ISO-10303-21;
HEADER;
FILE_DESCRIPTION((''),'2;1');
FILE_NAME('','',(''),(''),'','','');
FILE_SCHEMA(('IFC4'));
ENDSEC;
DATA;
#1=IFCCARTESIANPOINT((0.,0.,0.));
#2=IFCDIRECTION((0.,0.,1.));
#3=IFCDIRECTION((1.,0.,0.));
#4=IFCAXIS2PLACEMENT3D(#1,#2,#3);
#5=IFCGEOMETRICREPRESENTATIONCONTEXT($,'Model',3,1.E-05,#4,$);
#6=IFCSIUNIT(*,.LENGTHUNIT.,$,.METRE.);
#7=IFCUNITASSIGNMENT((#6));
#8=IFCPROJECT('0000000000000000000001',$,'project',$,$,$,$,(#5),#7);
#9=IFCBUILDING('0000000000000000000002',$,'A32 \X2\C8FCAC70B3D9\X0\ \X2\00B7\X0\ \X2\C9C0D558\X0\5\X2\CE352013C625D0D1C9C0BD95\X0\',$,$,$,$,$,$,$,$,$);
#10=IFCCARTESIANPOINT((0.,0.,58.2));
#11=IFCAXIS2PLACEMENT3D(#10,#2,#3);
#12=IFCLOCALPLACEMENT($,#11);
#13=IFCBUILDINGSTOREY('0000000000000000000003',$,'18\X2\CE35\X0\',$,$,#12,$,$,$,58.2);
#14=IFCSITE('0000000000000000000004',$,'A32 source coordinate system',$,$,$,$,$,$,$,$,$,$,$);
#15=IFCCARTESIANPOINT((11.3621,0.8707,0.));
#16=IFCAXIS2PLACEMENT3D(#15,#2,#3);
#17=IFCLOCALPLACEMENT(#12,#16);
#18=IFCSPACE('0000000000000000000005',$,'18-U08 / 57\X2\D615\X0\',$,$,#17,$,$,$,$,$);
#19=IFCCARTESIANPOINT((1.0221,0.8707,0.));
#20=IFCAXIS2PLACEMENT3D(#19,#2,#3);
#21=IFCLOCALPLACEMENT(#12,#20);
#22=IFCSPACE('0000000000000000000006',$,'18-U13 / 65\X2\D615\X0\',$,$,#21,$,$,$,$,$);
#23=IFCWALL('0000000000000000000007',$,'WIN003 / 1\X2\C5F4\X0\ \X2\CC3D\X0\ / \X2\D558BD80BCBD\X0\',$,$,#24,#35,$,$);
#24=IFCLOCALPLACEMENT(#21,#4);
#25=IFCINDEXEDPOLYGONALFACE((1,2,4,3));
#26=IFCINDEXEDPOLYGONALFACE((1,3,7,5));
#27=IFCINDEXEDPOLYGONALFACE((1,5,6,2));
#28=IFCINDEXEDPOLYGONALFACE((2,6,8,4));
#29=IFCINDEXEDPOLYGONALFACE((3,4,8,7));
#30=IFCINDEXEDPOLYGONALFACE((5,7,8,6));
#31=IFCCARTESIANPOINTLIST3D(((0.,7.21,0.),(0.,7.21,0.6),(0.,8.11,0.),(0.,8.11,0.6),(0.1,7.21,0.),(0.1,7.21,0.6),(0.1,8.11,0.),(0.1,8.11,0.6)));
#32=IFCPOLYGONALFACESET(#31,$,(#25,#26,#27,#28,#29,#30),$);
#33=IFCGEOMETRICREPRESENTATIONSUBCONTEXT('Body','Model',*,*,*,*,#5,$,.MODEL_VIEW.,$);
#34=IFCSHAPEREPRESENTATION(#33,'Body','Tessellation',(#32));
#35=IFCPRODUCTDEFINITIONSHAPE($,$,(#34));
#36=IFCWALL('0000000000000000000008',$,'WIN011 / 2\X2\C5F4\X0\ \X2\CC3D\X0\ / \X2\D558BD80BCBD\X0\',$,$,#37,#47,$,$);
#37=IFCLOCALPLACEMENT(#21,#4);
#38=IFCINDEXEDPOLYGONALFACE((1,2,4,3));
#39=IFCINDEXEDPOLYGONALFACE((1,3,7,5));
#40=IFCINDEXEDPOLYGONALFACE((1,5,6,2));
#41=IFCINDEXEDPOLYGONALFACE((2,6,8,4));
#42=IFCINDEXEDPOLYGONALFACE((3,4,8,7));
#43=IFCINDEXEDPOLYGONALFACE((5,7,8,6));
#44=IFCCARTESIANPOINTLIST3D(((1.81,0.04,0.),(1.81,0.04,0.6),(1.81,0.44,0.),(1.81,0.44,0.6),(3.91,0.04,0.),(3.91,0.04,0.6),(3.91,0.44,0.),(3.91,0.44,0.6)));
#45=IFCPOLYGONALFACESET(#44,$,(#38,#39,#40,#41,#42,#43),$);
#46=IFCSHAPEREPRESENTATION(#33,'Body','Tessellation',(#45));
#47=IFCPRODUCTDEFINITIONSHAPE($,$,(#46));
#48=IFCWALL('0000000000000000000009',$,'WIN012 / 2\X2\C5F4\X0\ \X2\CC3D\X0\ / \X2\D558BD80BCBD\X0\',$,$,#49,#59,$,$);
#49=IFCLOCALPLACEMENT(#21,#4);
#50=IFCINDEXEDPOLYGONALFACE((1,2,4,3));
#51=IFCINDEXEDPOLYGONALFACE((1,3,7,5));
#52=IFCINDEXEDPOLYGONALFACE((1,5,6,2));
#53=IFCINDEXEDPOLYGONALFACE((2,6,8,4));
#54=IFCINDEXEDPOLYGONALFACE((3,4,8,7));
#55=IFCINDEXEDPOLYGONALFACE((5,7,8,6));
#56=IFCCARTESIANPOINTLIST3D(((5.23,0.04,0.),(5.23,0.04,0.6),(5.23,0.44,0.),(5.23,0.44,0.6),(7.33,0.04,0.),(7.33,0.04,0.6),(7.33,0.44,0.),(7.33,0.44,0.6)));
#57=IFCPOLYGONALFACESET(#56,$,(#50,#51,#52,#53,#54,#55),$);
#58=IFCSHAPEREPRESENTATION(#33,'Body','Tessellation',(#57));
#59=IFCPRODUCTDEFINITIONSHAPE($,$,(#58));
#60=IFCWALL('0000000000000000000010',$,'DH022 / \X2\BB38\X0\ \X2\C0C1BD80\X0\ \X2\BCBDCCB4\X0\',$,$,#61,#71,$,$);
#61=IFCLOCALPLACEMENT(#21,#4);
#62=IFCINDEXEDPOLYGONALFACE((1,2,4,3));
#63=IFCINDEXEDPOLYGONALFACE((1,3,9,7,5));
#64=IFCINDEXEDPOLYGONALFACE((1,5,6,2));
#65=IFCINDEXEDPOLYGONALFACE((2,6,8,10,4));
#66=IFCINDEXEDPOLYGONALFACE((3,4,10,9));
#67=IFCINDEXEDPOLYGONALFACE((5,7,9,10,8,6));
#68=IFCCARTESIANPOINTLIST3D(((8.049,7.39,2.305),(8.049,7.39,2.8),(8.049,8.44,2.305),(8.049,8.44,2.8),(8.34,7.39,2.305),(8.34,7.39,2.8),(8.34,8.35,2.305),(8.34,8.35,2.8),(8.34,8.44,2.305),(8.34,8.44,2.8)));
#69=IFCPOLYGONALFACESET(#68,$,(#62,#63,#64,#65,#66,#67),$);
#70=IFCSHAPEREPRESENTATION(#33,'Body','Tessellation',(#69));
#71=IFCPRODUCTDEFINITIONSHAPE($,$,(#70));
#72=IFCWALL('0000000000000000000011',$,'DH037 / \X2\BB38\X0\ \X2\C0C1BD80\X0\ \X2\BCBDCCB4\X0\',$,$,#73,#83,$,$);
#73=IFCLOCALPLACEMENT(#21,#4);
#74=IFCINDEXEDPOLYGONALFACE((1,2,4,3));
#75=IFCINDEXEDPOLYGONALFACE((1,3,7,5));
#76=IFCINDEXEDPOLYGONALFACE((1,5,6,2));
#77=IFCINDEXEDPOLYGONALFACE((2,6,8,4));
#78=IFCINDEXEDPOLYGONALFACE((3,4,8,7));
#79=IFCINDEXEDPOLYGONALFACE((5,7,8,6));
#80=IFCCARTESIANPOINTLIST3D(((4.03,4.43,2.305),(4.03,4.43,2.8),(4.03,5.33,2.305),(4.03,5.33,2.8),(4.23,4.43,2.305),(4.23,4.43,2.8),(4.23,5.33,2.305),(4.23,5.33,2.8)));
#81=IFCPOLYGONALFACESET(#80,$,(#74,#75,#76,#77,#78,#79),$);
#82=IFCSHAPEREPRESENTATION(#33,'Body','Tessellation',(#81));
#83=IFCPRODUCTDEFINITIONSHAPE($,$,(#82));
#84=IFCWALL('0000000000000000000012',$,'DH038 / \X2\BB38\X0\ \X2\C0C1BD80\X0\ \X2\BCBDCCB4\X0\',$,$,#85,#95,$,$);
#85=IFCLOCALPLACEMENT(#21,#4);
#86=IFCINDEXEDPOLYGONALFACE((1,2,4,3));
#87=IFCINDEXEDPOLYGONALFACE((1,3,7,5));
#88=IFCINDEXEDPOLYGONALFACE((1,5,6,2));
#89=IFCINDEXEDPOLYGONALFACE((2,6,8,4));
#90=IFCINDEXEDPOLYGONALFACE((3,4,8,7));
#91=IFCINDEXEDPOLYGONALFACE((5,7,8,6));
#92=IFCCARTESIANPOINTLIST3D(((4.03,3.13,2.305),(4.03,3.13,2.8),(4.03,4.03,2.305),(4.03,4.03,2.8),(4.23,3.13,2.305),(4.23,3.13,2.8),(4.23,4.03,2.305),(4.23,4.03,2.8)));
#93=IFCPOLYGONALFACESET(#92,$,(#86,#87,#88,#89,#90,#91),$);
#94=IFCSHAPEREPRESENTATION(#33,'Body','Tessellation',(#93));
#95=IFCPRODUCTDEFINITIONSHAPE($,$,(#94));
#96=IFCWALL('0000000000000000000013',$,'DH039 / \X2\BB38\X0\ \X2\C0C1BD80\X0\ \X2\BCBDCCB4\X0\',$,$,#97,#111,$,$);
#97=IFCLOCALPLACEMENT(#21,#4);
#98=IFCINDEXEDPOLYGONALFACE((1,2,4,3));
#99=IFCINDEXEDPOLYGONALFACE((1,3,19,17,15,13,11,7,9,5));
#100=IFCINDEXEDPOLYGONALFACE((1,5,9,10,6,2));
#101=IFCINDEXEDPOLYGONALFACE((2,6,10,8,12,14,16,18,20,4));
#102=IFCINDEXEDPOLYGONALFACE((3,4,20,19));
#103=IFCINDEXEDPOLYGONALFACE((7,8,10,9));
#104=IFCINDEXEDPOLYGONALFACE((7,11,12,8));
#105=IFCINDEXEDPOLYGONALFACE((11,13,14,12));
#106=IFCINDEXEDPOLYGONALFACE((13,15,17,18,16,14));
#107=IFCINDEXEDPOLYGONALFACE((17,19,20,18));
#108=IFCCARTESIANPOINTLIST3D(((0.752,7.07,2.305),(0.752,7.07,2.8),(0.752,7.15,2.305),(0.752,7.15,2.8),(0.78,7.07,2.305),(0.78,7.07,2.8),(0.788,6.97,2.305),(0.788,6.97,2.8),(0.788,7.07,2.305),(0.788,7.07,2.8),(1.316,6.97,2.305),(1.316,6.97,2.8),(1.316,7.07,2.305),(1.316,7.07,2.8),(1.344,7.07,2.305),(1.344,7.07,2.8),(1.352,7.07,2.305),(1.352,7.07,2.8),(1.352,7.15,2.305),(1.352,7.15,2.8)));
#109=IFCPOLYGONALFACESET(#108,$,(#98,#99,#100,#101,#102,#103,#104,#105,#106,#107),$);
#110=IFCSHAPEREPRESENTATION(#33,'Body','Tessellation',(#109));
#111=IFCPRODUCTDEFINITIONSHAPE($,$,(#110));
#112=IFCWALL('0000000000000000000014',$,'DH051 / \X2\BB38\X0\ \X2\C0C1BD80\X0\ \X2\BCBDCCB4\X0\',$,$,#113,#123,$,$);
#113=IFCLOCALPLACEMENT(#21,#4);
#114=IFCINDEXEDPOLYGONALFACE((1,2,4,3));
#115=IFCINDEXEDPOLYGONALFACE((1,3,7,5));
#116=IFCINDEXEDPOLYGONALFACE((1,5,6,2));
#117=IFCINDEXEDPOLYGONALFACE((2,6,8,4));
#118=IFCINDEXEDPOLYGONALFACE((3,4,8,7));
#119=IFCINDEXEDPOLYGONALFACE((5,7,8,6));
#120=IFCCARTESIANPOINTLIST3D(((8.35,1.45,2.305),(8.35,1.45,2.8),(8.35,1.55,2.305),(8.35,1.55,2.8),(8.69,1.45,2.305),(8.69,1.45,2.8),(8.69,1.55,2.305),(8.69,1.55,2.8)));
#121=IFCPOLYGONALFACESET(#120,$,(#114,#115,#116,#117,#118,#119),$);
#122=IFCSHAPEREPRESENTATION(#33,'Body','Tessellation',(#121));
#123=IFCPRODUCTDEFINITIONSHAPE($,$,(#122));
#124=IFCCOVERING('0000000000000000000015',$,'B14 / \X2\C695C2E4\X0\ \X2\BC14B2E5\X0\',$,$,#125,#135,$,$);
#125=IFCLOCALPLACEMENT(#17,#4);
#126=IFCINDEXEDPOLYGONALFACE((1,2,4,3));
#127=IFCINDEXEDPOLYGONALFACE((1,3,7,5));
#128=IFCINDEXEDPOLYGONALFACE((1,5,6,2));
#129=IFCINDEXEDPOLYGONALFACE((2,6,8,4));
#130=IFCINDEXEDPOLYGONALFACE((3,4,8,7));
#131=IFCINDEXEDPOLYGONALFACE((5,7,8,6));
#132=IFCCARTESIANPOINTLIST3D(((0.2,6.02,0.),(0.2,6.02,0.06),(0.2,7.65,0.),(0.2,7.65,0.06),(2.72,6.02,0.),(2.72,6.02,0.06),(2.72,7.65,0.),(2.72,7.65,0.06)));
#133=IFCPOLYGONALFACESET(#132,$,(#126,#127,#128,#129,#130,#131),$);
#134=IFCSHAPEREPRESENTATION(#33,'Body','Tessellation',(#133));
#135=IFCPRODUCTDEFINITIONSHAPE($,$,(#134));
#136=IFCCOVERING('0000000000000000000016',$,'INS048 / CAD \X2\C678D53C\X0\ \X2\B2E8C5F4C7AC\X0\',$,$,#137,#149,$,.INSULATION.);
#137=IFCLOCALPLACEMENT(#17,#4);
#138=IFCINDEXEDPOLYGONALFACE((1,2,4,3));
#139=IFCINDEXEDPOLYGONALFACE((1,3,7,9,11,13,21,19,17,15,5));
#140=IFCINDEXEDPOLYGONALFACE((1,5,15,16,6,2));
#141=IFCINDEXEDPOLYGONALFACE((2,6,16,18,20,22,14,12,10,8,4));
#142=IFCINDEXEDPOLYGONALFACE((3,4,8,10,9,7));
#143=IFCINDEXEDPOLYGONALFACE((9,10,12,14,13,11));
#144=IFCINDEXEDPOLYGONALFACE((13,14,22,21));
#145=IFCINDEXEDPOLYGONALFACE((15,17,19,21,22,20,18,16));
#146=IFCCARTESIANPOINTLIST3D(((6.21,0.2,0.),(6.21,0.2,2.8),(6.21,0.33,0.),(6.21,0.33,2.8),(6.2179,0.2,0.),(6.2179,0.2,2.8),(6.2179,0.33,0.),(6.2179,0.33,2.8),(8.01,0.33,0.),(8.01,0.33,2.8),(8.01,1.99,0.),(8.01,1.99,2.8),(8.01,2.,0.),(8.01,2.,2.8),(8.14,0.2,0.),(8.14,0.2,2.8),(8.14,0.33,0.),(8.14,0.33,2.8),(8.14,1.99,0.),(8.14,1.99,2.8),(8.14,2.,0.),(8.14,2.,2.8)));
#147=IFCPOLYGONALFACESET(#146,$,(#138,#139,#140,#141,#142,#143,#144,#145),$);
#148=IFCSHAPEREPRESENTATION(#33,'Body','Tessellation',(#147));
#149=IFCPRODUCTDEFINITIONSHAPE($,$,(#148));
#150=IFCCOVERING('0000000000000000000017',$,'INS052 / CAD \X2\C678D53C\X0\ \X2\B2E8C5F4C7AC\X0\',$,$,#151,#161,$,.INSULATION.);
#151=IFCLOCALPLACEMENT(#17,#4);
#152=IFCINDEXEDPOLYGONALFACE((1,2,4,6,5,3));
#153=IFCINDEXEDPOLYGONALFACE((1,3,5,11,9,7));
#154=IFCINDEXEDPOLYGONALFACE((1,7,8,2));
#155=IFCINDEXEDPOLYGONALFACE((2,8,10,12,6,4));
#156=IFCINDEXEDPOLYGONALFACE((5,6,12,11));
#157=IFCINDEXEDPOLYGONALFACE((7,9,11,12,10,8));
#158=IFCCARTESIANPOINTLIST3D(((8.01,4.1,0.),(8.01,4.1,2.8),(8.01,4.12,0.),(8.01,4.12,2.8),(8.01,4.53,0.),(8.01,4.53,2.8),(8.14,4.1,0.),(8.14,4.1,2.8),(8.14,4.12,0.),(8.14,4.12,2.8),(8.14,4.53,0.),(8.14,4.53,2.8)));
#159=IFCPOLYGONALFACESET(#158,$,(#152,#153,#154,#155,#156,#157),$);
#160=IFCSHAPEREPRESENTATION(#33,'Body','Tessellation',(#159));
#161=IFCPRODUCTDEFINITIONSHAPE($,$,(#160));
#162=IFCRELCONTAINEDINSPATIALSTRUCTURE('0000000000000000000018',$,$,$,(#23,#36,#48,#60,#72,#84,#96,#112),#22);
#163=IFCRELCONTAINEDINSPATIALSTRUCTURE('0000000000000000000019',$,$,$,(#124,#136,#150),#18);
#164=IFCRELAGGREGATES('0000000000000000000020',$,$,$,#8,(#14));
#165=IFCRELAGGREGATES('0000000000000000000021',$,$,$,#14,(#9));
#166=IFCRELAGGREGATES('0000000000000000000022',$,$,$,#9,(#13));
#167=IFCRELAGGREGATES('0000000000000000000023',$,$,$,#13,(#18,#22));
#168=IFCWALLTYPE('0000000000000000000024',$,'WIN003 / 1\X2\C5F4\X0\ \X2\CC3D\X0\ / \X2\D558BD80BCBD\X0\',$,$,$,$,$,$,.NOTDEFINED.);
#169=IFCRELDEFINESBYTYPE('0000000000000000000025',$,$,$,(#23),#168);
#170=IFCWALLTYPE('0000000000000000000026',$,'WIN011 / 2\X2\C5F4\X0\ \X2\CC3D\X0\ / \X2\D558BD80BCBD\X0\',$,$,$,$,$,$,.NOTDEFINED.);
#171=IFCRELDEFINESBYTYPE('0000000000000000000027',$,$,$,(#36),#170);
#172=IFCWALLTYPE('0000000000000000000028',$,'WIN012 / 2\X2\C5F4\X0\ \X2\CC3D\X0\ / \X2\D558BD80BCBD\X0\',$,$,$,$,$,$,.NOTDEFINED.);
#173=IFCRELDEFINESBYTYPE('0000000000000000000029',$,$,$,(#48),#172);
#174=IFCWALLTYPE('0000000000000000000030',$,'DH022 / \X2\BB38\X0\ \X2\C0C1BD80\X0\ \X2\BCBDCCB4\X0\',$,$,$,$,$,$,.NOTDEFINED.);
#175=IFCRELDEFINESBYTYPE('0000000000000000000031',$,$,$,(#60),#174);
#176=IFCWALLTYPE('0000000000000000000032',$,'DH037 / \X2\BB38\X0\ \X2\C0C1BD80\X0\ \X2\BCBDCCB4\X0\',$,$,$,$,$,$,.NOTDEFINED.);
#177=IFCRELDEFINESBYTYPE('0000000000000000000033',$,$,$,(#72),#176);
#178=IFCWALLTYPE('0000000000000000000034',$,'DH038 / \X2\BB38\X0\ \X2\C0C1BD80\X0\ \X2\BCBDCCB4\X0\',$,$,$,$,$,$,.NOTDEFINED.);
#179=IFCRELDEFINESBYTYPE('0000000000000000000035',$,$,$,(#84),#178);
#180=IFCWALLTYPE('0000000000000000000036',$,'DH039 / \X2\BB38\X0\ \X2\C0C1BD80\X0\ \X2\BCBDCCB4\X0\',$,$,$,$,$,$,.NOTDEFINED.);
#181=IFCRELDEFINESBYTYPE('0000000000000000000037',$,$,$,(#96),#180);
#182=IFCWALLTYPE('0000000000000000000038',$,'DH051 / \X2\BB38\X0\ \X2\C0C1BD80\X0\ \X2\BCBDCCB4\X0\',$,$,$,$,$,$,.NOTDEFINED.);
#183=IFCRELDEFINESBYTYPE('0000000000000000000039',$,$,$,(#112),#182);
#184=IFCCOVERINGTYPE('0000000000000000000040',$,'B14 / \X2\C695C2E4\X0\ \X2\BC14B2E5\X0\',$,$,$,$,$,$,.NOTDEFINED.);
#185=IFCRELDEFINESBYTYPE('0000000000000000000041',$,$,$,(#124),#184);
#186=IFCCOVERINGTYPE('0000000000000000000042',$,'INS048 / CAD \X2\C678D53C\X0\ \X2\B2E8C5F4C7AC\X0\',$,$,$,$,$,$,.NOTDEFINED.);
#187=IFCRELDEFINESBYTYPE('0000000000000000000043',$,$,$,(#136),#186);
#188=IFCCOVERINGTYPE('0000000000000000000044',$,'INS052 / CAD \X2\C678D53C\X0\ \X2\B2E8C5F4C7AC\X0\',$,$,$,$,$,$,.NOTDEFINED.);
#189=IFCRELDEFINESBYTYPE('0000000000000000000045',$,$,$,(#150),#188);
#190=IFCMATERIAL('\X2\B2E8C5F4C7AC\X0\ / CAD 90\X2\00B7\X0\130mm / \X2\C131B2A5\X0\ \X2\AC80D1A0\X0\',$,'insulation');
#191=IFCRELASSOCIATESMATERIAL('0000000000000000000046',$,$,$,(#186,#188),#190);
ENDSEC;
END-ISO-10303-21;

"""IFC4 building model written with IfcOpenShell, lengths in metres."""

from ifc_helpers import new_model, si_unit, frame, origin, origin_with_axes, place, context, subcontext, project, spatial, polyline, outline, extrude, source, transform, mapped, material, type_object, type_shapes, element, save


model = new_model("IFC4")

# Units and contexts
model_context = context("Model", 3, precision=1e-05, world=origin_with_axes())
body_context = subcontext(model_context, "Body", "Model", "MODEL_VIEW")
ifc_project = project(units=[si_unit("LENGTHUNIT", "METRE")], contexts=[model_context])

# Site, building, storey, space
site = spatial("IfcSite", under=ifc_project, Name="A32 source coordinate system")
building = spatial("IfcBuilding", under=site, Name="A32 주거동 · 지하5층–옥탑지붕")
storey_placement = place(None, frame((0.0, 0.0, 58.2), z_axis=(0.0, 0.0, 1.0), x_axis=(1.0, 0.0, 0.0)))
storey = spatial("IfcBuildingStorey", under=building, at=storey_placement, Name="18층", Elevation=58.2)
space_1_placement = place(storey_placement, frame((11.3621, 0.8707, 0.0), z_axis=(0.0, 0.0, 1.0), x_axis=(1.0, 0.0, 0.0)))
space_1 = spatial("IfcSpace", under=storey, at=space_1_placement, Name="18-U08 / 57형")

# Shared definitions
space_2_placement = place(storey_placement, frame((1.0221, 0.8707, 0.0), z_axis=(0.0, 0.0, 1.0), x_axis=(1.0, 0.0, 0.0)))
space_2 = spatial("IfcSpace", under=storey, at=space_2_placement, Name="18-U13 / 65형")

# Walls
wall_type_1 = type_object("IfcWallType", Name="WIN003 / 1열 창 / 하부벽", PredefinedType="NOTDEFINED")
shared_shape_1 = source(origin(), body_context, "Body", "SweptSolid", [
    extrude(outline(polyline([(0.0, 8.11), (0.1, 8.11), (0.1, 7.21), (0.0, 7.21), (0.0, 8.11)])), origin(), (0.0, 0.0, 1.0), 0.6),
])
type_shapes(wall_type_1, [shared_shape_1])
wall_1_placement = place(space_2_placement, origin_with_axes())
element("IfcWall", 1, at=wall_1_placement, inside=space_2, type_object=wall_type_1, Name="WIN003 / 1열 창 / 하부벽", context=body_context, shape_type="MappedRepresentation", body=[
    mapped(shared_shape_1, transform((0.0, 0.0, 0.0), scale=1.0)),
])
wall_type_2 = type_object("IfcWallType", Name="WIN011 / 2열 창 / 하부벽", PredefinedType="NOTDEFINED")
shared_shape_2 = source(origin(), body_context, "Body", "SweptSolid", [
    extrude(outline(polyline([(1.81, 0.44), (3.91, 0.44), (3.91, 0.04), (1.81, 0.04), (1.81, 0.44)])), origin(), (0.0, 0.0, 1.0), 0.6),
])
type_shapes(wall_type_2, [shared_shape_2])
wall_2_placement = place(space_2_placement, origin_with_axes())
element("IfcWall", 2, at=wall_2_placement, inside=space_2, type_object=wall_type_2, Name="WIN011 / 2열 창 / 하부벽", context=body_context, shape_type="MappedRepresentation", body=[
    mapped(shared_shape_2, transform((0.0, 0.0, 0.0), scale=1.0)),
])
wall_type_3 = type_object("IfcWallType", Name="WIN012 / 2열 창 / 하부벽", PredefinedType="NOTDEFINED")
shared_shape_3 = source(origin(), body_context, "Body", "SweptSolid", [
    extrude(outline(polyline([(5.23, 0.44), (7.33, 0.44), (7.33, 0.04), (5.23, 0.04), (5.23, 0.44)])), origin(), (0.0, 0.0, 1.0), 0.6),
])
type_shapes(wall_type_3, [shared_shape_3])
wall_3_placement = place(space_2_placement, origin_with_axes())
element("IfcWall", 3, at=wall_3_placement, inside=space_2, type_object=wall_type_3, Name="WIN012 / 2열 창 / 하부벽", context=body_context, shape_type="MappedRepresentation", body=[
    mapped(shared_shape_3, transform((0.0, 0.0, 0.0), scale=1.0)),
])
wall_type_4 = type_object("IfcWallType", Name="DH022 / 문 상부 벽체", PredefinedType="NOTDEFINED")
shared_shape_4 = source(origin(), body_context, "Body", "SweptSolid", [
    extrude(outline(polyline([(8.049, 7.39), (8.049, 8.44), (8.34, 8.44), (8.34, 8.35), (8.34, 8.35), (8.34, 7.39), (8.049, 7.39)])), frame((0.0, 0.0, 2.305)), (0.0, 0.0, 1.0), 0.495),
])
type_shapes(wall_type_4, [shared_shape_4])
wall_4_placement = place(space_2_placement, origin_with_axes())
element("IfcWall", 4, at=wall_4_placement, inside=space_2, type_object=wall_type_4, Name="DH022 / 문 상부 벽체", context=body_context, shape_type="MappedRepresentation", body=[
    mapped(shared_shape_4, transform((0.0, 0.0, 0.0), scale=1.0)),
])
wall_type_5 = type_object("IfcWallType", Name="DH037 / 문 상부 벽체", PredefinedType="NOTDEFINED")
shared_shape_5 = source(origin(), body_context, "Body", "SweptSolid", [
    extrude(outline(polyline([(4.23, 5.33), (4.23, 4.43), (4.03, 4.43), (4.03, 5.33), (4.23, 5.33)])), frame((0.0, 0.0, 2.305)), (0.0, 0.0, 1.0), 0.495),
])
type_shapes(wall_type_5, [shared_shape_5])
wall_5_placement = place(space_2_placement, origin_with_axes())
element("IfcWall", 5, at=wall_5_placement, inside=space_2, type_object=wall_type_5, Name="DH037 / 문 상부 벽체", context=body_context, shape_type="MappedRepresentation", body=[
    mapped(shared_shape_5, transform((0.0, 0.0, 0.0), scale=1.0)),
])
wall_type_6 = type_object("IfcWallType", Name="DH038 / 문 상부 벽체", PredefinedType="NOTDEFINED")
shared_shape_6 = source(origin(), body_context, "Body", "SweptSolid", [
    extrude(outline(polyline([(4.23, 4.03), (4.23, 3.13), (4.03, 3.13), (4.03, 4.03), (4.23, 4.03)])), frame((0.0, 0.0, 2.305)), (0.0, 0.0, 1.0), 0.495),
])
type_shapes(wall_type_6, [shared_shape_6])
wall_6_placement = place(space_2_placement, origin_with_axes())
element("IfcWall", 6, at=wall_6_placement, inside=space_2, type_object=wall_type_6, Name="DH038 / 문 상부 벽체", context=body_context, shape_type="MappedRepresentation", body=[
    mapped(shared_shape_6, transform((0.0, 0.0, 0.0), scale=1.0)),
])
wall_type_7 = type_object("IfcWallType", Name="DH039 / 문 상부 벽체", PredefinedType="NOTDEFINED")
shared_shape_7 = source(origin(), body_context, "Body", "SweptSolid", [
    extrude(outline(polyline([(1.316, 7.07), (1.316, 6.97), (0.788, 6.97), (0.788, 7.07), (0.78, 7.07), (0.752, 7.07), (0.752, 7.15), (1.352, 7.15), (1.352, 7.07), (1.344, 7.07), (1.316, 7.07)])), frame((0.0, 0.0, 2.305)), (0.0, 0.0, 1.0), 0.495),
])
type_shapes(wall_type_7, [shared_shape_7])
wall_7_placement = place(space_2_placement, origin_with_axes())
element("IfcWall", 7, at=wall_7_placement, inside=space_2, type_object=wall_type_7, Name="DH039 / 문 상부 벽체", context=body_context, shape_type="MappedRepresentation", body=[
    mapped(shared_shape_7, transform((0.0, 0.0, 0.0), scale=1.0)),
])
wall_type_8 = type_object("IfcWallType", Name="DH051 / 문 상부 벽체", PredefinedType="NOTDEFINED")
shared_shape_8 = source(origin(), body_context, "Body", "SweptSolid", [
    extrude(outline(polyline([(8.69, 1.55), (8.69, 1.45), (8.35, 1.45), (8.35, 1.55), (8.69, 1.55)])), frame((0.0, 0.0, 2.305)), (0.0, 0.0, 1.0), 0.495),
])
type_shapes(wall_type_8, [shared_shape_8])
wall_8_placement = place(space_2_placement, origin_with_axes())
element("IfcWall", 8, at=wall_8_placement, inside=space_2, type_object=wall_type_8, Name="DH051 / 문 상부 벽체", context=body_context, shape_type="MappedRepresentation", body=[
    mapped(shared_shape_8, transform((0.0, 0.0, 0.0), scale=1.0)),
])

# Coverings
covering_type_1 = type_object("IfcCoveringType", Name="B14 / 욕실 바닥", PredefinedType="NOTDEFINED")
shared_shape_9 = source(origin(), body_context, "Body", "SweptSolid", [
    extrude(outline(polyline([(0.2, 7.65), (2.72, 7.65), (2.72, 6.02), (0.2, 6.02), (0.2, 7.65)])), origin(), (0.0, 0.0, 1.0), 0.06),
])
type_shapes(covering_type_1, [shared_shape_9])
covering_1_placement = place(space_1_placement, origin_with_axes())
element("IfcCovering", 9, at=covering_1_placement, inside=space_1, type_object=covering_type_1, Name="B14 / 욕실 바닥", context=body_context, shape_type="MappedRepresentation", body=[
    mapped(shared_shape_9, transform((0.0, 0.0, 0.0), scale=1.0)),
])
ifc_material = material(Name="단열재 / CAD 90·130mm / 성능 검토", Category="insulation")
covering_type_2 = type_object("IfcCoveringType", Name="INS048 / CAD 외피 단열재", PredefinedType="NOTDEFINED", material=ifc_material)
shared_shape_10 = source(origin(), body_context, "Body", "SweptSolid", [
    extrude(outline(polyline([(8.01, 1.99), (8.01, 2.0), (8.14, 2.0), (8.14, 1.99), (8.14, 0.33), (8.14, 0.2), (6.2179, 0.2), (6.21, 0.2), (6.21, 0.33), (6.2179, 0.33), (8.01, 0.33), (8.01, 1.99)])), origin(), (0.0, 0.0, 1.0), 2.8),
])
type_shapes(covering_type_2, [shared_shape_10])
covering_2_placement = place(space_1_placement, origin_with_axes())
element("IfcCovering", 10, at=covering_2_placement, inside=space_1, type_object=covering_type_2, Name="INS048 / CAD 외피 단열재", PredefinedType="INSULATION", context=body_context, shape_type="MappedRepresentation", body=[
    mapped(shared_shape_10, transform((0.0, 0.0, 0.0), scale=1.0)),
])
covering_type_3 = type_object("IfcCoveringType", Name="INS052 / CAD 외피 단열재", PredefinedType="NOTDEFINED", material=ifc_material)
shared_shape_11 = source(origin(), body_context, "Body", "SweptSolid", [
    extrude(outline(polyline([(8.14, 4.1), (8.01, 4.1), (8.01, 4.12), (8.01, 4.53), (8.14, 4.53), (8.14, 4.12), (8.14, 4.1)])), origin(), (0.0, 0.0, 1.0), 2.8),
])
type_shapes(covering_type_3, [shared_shape_11])
covering_3_placement = place(space_1_placement, origin_with_axes())
element("IfcCovering", 11, at=covering_3_placement, inside=space_1, type_object=covering_type_3, Name="INS052 / CAD 외피 단열재", PredefinedType="INSULATION", context=body_context, shape_type="MappedRepresentation", body=[
    mapped(shared_shape_11, transform((0.0, 0.0, 0.0), scale=1.0)),
])

save(model, "model.ifc")
